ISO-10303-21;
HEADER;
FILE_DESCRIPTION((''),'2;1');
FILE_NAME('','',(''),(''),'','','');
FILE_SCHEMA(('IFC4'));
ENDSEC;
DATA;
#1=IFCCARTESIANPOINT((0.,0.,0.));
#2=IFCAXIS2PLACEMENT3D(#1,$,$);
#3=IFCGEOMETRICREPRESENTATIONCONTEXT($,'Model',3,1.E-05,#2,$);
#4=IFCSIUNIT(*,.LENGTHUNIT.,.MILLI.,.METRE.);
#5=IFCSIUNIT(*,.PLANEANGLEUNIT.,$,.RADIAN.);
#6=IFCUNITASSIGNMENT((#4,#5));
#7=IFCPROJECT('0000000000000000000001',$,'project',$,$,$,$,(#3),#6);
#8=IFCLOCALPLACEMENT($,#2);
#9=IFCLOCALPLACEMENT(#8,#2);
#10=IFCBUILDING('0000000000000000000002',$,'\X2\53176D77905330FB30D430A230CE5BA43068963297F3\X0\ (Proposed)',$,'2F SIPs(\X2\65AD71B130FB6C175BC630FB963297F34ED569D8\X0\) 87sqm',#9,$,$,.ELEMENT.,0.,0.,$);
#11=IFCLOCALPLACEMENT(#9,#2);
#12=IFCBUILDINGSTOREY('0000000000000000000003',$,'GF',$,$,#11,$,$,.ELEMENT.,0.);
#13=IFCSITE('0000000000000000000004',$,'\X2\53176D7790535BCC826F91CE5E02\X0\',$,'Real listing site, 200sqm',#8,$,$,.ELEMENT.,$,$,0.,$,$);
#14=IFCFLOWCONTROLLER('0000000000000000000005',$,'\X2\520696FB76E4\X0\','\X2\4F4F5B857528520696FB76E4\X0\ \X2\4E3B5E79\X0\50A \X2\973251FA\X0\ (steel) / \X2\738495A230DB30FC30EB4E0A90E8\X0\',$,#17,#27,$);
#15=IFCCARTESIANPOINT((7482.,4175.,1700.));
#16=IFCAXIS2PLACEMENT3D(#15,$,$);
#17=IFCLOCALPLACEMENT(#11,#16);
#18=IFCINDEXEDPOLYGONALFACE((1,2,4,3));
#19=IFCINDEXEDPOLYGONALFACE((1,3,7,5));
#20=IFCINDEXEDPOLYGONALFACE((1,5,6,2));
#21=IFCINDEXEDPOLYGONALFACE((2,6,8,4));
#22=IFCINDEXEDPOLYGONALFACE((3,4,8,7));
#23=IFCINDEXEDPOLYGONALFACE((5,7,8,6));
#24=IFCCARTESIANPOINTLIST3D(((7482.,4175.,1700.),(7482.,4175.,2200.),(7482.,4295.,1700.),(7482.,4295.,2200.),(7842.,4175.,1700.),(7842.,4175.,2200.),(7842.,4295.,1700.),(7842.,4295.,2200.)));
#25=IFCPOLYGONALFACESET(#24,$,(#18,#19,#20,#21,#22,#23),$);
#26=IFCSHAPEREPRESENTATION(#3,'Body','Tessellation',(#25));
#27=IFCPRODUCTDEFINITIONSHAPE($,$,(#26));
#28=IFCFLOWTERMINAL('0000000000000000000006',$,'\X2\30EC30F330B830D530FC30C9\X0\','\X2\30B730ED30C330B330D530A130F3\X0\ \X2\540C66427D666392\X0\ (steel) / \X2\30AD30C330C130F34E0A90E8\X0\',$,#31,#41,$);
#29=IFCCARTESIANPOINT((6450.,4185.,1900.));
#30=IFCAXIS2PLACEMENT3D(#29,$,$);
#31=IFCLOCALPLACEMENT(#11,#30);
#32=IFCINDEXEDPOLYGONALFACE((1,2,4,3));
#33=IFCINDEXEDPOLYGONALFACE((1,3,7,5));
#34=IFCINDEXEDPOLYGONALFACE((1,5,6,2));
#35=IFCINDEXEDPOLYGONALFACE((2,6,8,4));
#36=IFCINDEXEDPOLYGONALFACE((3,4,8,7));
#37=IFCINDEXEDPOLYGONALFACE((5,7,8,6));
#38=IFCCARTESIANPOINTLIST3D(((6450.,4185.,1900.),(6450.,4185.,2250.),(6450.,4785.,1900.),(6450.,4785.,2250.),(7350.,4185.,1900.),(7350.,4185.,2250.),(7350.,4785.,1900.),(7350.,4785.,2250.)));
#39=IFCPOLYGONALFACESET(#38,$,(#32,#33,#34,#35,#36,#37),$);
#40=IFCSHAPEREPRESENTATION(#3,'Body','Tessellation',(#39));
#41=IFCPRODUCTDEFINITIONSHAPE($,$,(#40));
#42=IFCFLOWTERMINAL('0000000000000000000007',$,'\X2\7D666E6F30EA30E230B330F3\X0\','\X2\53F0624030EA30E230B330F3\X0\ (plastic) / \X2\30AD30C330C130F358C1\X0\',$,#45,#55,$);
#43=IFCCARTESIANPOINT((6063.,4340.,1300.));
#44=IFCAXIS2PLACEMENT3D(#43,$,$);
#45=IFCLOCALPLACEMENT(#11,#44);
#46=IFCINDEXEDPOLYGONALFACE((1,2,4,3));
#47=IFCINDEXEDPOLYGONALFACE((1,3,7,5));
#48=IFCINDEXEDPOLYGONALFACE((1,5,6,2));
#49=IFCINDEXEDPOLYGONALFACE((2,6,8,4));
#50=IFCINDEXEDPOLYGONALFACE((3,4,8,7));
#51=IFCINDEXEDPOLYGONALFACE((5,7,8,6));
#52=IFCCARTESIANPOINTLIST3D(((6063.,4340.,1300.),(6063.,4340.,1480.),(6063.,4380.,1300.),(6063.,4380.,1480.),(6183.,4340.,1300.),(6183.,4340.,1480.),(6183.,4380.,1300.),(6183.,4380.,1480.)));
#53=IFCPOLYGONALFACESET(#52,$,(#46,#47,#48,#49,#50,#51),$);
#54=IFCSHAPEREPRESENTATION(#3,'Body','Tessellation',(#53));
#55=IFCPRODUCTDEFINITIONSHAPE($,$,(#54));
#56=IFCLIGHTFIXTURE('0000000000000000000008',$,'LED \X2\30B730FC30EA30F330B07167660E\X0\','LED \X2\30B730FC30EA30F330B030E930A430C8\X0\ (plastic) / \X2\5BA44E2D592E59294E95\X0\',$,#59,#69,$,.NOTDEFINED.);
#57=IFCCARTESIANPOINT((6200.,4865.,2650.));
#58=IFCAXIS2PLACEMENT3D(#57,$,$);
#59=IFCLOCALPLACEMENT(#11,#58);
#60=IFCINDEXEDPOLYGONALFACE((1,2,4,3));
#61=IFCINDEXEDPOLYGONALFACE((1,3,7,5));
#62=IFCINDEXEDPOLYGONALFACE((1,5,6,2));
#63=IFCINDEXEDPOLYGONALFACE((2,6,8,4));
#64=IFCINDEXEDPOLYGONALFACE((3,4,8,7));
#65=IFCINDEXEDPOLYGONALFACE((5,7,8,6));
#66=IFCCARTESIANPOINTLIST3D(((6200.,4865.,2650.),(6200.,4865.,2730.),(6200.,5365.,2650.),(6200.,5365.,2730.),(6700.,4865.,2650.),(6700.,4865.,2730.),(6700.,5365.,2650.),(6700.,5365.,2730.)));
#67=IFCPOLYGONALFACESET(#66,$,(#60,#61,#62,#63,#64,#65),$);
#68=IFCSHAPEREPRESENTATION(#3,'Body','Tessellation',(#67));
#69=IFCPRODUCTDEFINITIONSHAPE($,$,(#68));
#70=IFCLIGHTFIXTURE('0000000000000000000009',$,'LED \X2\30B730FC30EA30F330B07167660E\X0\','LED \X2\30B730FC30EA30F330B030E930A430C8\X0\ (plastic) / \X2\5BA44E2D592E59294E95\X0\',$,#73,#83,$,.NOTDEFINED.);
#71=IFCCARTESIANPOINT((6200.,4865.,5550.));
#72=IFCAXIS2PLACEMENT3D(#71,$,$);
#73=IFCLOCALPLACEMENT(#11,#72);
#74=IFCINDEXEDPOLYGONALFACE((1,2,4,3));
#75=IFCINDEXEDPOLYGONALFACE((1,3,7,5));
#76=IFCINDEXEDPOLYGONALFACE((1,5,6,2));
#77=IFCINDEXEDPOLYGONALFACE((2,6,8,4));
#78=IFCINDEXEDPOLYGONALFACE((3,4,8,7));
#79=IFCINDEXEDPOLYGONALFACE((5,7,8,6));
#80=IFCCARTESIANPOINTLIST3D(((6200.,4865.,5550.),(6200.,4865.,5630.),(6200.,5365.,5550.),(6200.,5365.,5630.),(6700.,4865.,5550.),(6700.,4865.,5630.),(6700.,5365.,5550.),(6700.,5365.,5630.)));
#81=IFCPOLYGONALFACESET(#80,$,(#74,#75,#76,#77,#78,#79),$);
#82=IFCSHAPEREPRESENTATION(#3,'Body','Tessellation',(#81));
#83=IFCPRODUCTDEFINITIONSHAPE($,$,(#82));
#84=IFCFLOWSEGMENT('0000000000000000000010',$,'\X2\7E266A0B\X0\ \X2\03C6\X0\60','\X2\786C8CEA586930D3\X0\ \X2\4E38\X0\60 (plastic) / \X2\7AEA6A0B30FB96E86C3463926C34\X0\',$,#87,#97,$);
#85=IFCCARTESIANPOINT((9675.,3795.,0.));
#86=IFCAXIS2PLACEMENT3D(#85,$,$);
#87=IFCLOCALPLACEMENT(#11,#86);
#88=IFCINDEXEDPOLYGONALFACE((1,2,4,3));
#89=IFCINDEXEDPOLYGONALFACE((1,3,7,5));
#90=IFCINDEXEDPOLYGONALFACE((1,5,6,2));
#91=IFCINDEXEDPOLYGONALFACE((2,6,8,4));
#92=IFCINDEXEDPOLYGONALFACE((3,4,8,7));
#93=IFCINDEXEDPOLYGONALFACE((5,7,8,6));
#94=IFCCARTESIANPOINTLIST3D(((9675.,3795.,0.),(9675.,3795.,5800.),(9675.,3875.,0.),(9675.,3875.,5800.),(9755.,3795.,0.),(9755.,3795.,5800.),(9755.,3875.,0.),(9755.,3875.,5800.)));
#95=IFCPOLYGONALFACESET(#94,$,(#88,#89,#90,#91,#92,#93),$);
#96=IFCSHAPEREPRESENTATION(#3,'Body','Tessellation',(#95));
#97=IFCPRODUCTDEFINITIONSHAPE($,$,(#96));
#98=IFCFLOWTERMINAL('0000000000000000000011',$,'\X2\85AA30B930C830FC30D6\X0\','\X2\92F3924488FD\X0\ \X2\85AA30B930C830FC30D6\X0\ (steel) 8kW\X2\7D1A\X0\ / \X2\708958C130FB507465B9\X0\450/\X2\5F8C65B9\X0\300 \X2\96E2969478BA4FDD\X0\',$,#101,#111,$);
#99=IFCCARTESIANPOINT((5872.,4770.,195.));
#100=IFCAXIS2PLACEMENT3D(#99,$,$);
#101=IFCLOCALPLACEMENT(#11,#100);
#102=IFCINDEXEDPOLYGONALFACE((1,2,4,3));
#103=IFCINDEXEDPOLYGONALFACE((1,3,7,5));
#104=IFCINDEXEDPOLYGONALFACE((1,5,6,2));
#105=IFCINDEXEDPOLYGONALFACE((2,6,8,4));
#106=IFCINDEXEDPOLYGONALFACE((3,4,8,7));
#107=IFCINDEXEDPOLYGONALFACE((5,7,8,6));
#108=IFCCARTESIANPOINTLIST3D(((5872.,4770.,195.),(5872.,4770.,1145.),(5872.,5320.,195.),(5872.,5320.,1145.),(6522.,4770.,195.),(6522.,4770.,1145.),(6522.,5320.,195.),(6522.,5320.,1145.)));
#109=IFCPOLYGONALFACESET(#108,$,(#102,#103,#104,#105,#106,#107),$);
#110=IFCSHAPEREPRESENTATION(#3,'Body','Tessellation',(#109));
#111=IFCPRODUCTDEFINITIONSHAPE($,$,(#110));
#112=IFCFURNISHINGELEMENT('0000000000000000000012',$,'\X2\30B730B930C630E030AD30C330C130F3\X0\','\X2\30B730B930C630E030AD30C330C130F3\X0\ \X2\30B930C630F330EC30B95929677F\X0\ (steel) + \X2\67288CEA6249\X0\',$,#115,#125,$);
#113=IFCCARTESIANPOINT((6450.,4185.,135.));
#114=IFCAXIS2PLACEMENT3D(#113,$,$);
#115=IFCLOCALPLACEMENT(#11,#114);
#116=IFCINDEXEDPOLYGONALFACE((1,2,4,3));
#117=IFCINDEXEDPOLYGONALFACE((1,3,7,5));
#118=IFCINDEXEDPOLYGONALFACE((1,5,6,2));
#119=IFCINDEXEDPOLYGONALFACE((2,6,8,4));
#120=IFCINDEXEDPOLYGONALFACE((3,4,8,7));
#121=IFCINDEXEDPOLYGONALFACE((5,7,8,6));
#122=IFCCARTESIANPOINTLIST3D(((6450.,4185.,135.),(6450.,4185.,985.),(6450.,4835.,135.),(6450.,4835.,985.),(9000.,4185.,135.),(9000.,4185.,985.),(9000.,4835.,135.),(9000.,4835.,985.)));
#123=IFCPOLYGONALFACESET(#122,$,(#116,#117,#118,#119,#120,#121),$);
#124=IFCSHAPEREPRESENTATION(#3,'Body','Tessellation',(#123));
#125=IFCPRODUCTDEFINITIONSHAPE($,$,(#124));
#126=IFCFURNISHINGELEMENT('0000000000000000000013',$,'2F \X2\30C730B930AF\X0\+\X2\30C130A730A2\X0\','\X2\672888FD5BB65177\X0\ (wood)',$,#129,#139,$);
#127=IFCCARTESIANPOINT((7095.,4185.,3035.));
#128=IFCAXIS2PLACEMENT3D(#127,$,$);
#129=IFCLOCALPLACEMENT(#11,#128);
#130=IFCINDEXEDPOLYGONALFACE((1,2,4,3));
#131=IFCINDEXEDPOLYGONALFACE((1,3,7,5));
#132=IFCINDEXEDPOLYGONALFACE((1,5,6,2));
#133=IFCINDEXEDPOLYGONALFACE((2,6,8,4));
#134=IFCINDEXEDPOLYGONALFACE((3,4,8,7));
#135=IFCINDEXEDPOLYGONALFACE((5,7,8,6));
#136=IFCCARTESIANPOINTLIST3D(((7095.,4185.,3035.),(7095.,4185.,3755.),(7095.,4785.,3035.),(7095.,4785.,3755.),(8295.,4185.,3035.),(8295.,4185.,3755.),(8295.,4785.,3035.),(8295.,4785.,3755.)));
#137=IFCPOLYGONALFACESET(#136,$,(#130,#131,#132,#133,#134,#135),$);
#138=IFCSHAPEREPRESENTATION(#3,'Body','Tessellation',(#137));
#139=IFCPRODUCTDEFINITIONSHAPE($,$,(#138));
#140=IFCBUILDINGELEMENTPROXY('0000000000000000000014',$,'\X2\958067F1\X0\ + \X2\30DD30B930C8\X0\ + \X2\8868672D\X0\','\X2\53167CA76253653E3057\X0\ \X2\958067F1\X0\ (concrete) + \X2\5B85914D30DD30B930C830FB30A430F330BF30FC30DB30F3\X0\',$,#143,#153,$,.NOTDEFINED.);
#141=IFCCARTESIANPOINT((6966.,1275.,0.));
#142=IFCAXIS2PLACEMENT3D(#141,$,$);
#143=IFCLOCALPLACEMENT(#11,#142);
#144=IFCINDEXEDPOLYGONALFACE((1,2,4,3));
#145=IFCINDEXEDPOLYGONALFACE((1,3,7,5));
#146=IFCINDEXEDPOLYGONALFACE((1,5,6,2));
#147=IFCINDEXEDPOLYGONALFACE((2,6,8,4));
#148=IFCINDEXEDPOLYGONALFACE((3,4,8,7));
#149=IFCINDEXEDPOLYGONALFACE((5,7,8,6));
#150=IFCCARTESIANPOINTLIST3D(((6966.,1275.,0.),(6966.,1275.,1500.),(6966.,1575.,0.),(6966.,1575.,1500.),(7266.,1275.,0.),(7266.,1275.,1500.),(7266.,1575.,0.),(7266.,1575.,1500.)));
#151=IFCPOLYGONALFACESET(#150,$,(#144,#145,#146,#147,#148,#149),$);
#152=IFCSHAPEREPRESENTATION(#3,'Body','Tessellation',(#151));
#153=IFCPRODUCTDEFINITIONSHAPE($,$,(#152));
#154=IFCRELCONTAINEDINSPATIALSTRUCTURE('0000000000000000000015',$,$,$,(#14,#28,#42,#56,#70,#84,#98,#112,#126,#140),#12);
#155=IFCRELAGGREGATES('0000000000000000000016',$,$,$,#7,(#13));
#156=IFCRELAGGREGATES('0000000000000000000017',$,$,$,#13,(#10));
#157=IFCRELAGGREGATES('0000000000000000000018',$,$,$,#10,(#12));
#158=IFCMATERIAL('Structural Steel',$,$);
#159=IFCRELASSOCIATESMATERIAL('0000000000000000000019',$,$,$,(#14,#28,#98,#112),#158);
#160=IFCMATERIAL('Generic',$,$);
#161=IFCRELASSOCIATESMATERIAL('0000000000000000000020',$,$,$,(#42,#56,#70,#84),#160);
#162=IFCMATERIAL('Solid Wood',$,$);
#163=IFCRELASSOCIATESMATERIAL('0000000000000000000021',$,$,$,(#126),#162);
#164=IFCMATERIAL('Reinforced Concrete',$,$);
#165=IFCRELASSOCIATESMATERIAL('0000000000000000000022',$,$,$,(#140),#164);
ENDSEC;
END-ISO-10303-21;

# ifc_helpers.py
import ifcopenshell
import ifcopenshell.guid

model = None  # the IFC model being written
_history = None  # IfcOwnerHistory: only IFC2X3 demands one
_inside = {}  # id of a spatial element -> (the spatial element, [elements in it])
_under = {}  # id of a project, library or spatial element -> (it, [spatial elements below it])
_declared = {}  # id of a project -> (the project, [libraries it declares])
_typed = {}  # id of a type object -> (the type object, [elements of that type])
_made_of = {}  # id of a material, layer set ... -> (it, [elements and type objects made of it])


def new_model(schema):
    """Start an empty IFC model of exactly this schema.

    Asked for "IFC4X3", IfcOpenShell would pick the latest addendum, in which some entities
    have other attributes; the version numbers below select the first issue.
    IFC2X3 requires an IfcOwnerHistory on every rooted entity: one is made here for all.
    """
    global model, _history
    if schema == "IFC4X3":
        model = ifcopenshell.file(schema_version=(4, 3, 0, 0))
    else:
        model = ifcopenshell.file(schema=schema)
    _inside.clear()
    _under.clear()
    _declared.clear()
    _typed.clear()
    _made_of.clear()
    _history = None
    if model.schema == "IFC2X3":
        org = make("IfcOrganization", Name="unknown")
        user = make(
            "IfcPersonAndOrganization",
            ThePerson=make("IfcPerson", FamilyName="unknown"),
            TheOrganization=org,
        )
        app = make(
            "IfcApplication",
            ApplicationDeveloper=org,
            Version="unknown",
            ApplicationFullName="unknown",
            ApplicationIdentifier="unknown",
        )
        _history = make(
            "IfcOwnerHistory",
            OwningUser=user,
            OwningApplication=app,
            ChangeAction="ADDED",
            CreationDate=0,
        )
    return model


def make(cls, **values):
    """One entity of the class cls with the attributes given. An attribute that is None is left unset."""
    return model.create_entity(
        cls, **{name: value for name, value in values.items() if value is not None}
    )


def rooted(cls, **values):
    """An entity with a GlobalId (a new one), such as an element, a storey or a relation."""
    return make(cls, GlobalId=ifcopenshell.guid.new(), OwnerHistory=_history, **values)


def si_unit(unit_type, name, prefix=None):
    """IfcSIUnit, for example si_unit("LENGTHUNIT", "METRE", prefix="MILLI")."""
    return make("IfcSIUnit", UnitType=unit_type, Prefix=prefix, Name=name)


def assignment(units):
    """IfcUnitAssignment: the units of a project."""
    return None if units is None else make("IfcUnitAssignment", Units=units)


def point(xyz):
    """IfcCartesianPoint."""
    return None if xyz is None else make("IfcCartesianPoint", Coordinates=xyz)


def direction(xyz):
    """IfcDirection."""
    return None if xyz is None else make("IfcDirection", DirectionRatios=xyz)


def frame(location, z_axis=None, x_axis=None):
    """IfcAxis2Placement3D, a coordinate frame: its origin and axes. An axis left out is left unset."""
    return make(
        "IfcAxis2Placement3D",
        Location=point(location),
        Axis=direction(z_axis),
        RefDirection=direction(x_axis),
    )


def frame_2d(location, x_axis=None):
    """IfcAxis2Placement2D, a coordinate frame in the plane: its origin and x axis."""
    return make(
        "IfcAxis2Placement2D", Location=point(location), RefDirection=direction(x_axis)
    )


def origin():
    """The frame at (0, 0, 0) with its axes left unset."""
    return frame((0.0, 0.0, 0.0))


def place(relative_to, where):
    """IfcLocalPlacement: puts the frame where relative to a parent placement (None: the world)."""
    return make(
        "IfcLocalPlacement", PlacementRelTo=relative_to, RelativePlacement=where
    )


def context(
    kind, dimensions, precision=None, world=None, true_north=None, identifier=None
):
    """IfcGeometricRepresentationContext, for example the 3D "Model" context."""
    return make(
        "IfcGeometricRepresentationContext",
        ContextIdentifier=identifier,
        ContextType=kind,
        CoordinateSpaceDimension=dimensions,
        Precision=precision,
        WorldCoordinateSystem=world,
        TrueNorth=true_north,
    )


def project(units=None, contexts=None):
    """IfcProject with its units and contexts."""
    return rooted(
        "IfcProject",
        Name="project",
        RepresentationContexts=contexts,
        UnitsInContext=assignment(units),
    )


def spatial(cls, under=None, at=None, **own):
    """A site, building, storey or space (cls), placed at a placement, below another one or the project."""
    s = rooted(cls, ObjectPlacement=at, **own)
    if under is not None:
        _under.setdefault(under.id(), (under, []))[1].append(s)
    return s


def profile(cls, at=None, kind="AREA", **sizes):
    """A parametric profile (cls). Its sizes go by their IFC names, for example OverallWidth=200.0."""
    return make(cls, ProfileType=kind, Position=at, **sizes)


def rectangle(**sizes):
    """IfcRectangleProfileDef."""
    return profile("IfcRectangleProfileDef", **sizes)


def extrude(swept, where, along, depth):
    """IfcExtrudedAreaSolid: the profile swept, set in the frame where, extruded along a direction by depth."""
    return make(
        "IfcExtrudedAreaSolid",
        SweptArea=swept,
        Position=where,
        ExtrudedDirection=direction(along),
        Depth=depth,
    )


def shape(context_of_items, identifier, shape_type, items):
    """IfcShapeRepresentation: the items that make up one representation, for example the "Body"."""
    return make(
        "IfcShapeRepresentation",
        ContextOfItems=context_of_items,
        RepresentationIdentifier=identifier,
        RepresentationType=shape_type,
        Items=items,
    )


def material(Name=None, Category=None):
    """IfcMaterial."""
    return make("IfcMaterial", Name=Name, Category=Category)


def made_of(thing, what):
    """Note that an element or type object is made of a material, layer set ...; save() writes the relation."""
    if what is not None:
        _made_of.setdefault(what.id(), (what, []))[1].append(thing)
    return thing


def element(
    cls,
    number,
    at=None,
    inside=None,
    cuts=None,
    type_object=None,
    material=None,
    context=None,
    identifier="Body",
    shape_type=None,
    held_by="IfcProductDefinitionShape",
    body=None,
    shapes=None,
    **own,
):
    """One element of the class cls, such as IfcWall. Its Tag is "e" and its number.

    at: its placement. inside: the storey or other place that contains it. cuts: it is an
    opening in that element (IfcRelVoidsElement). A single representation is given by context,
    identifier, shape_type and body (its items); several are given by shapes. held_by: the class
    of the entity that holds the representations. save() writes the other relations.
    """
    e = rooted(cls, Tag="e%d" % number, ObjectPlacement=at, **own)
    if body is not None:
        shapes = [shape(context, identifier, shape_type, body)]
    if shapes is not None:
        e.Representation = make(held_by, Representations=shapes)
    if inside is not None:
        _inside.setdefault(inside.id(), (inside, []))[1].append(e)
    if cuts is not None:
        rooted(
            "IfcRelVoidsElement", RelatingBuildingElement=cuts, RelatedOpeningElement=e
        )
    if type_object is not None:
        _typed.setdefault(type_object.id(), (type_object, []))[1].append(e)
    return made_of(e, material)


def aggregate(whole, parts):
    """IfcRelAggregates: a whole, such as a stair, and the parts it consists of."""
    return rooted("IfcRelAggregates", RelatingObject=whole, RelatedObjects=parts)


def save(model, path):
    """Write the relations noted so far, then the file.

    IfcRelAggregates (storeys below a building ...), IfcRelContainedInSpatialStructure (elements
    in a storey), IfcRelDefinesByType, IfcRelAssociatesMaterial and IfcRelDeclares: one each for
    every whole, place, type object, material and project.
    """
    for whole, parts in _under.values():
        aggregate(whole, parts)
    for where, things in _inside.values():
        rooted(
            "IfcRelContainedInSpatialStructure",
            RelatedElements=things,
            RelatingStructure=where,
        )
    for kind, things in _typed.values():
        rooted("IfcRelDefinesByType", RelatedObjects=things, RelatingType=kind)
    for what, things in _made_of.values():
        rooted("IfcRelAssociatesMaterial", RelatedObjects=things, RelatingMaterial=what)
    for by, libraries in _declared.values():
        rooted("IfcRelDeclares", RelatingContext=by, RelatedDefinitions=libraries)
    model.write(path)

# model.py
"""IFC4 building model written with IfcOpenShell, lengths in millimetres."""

from ifc_helpers import new_model, si_unit, frame, frame_2d, origin, place, context, project, spatial, rectangle, extrude, material, element, save


model = new_model("IFC4")

# Units and contexts
model_context = context("Model", 3, precision=1e-05, world=origin())
ifc_project = project(units=[si_unit("LENGTHUNIT", "METRE", prefix="MILLI"), si_unit("PLANEANGLEUNIT", "RADIAN")], contexts=[model_context])

# Site, building, storey
site_placement = place(None, origin())
site = spatial("IfcSite", under=ifc_project, at=site_placement, Name="北海道富良野市", ObjectType="Real listing site, 200sqm", CompositionType="ELEMENT", RefElevation=0.0)
building_placement = place(site_placement, origin())
building = spatial("IfcBuilding", under=site, at=building_placement, Name="北海道・ピアノ室と防音 (Proposed)", ObjectType="2F SIPs(断熱・気密・防音仕様) 87sqm", CompositionType="ELEMENT", ElevationOfRefHeight=0.0, ElevationOfTerrain=0.0)
storey_placement = place(building_placement, origin())
storey = spatial("IfcBuildingStorey", under=building, at=storey_placement, Name="GF", CompositionType="ELEMENT", Elevation=0.0)

# Shared definitions
ifc_material_1 = material(Name="Solid Wood")

# Shared definitions
ifc_material_2 = material(Name="Structural Steel")

# Shared definitions
ifc_material_3 = material(Name="Reinforced Concrete")

# Flow controller
flow_controller_placement = place(storey_placement, frame((7482.0, 4175.0, 1700.0)))
element("IfcFlowController", 1, at=flow_controller_placement, inside=storey, material=ifc_material_2, Name="分電盤", Description="住宅用分電盤 主幹50A 露出 (steel) / 玄関ホール上部", context=model_context, shape_type="SweptSolid", body=[
    extrude(rectangle(XDim=360.0, YDim=120.0, at=frame_2d((180.0, 60.0))), frame((7482.0, 4175.0, 1700.0)), (0.0, 0.0, 1.0), 500.0),
])

# Flow terminals
flow_terminal_1_placement = place(storey_placement, frame((6450.0, 4185.0, 1900.0)))
element("IfcFlowTerminal", 2, at=flow_terminal_1_placement, inside=storey, material=ifc_material_2, Name="レンジフード", Description="シロッコファン 同時給排 (steel) / キッチン上部", context=model_context, shape_type="SweptSolid", body=[
    extrude(rectangle(XDim=900.0, YDim=600.0, at=frame_2d((450.0, 300.0))), frame((6450.0, 4185.0, 1900.0)), (0.0, 0.0, 1.0), 350.0),
])
ifc_material_4 = material(Name="Generic")
flow_terminal_2_placement = place(storey_placement, frame((6063.0, 4340.0, 1300.0)))
element("IfcFlowTerminal", 3, at=flow_terminal_2_placement, inside=storey, material=ifc_material_4, Name="給湯リモコン", Description="台所リモコン (plastic) / キッチン壁", context=model_context, shape_type="SweptSolid", body=[
    extrude(rectangle(XDim=120.0, YDim=40.0, at=frame_2d((60.0, 20.0))), frame((6063.0, 4340.0, 1300.0)), (0.0, 0.0, 1.0), 180.0),
])

# Light fixtures
light_fixture_1_placement = place(storey_placement, frame((6200.0, 4865.0, 2650.0)))
element("IfcLightFixture", 4, at=light_fixture_1_placement, inside=storey, material=ifc_material_4, Name="LED シーリング照明", Description="LED シーリングライト (plastic) / 室中央天井", PredefinedType="NOTDEFINED", context=model_context, shape_type="SweptSolid", body=[
    extrude(rectangle(XDim=500.0, YDim=500.0, at=frame_2d((250.0, 250.0))), frame((6200.0, 4865.0, 2650.0)), (0.0, 0.0, 1.0), 80.0),
])
light_fixture_2_placement = place(storey_placement, frame((6200.0, 4865.0, 5550.0)))
element("IfcLightFixture", 5, at=light_fixture_2_placement, inside=storey, material=ifc_material_4, Name="LED シーリング照明", Description="LED シーリングライト (plastic) / 室中央天井", PredefinedType="NOTDEFINED", context=model_context, shape_type="SweptSolid", body=[
    extrude(rectangle(XDim=500.0, YDim=500.0, at=frame_2d((250.0, 250.0))), frame((6200.0, 4865.0, 5550.0)), (0.0, 0.0, 1.0), 80.0),
])

# Flow segment
flow_segment_placement = place(storey_placement, frame((9675.0, 3795.0, 0.0)))
element("IfcFlowSegment", 6, at=flow_segment_placement, inside=storey, material=ifc_material_4, Name="縦樋 φ60", Description="硬質塩ビ 丸60 (plastic) / 竪樋・雨水排水", context=model_context, shape_type="SweptSolid", body=[
    extrude(rectangle(XDim=80.0, YDim=80.0, at=frame_2d((40.0, 40.0))), frame((9675.0, 3795.0, 0.0)), (0.0, 0.0, 1.0), 5800.0),
])

# Flow terminal
flow_terminal_3_placement = place(storey_placement, frame((5872.0, 4770.0, 195.0)))
element("IfcFlowTerminal", 7, at=flow_terminal_3_placement, inside=storey, material=ifc_material_2, Name="薪ストーブ", Description="鋳鉄製 薪ストーブ (steel) 8kW級 / 炉壁・側方450/後方300 離隔確保", context=model_context, shape_type="SweptSolid", body=[
    extrude(rectangle(XDim=650.0, YDim=550.0, at=frame_2d((325.0, 275.0))), frame((5872.0, 4770.0, 195.0)), (0.0, 0.0, 1.0), 950.0),
])

# Furnishing elements
furnishing_1_placement = place(storey_placement, frame((6450.0, 4185.0, 135.0)))
element("IfcFurnishingElement", 8, at=furnishing_1_placement, inside=storey, material=ifc_material_2, Name="システムキッチン", Description="システムキッチン ステンレス天板 (steel) + 木質扉", context=model_context, shape_type="SweptSolid", body=[
    extrude(rectangle(XDim=2550.0, YDim=650.0, at=frame_2d((1275.0, 325.0))), frame((6450.0, 4185.0, 135.0)), (0.0, 0.0, 1.0), 850.0),
])
furnishing_2_placement = place(storey_placement, frame((7095.0, 4185.0, 3035.0)))
element("IfcFurnishingElement", 9, at=furnishing_2_placement, inside=storey, material=ifc_material_1, Name="2F デスク+チェア", Description="木製家具 (wood)", context=model_context, shape_type="SweptSolid", body=[
    extrude(rectangle(XDim=1200.0, YDim=600.0, at=frame_2d((600.0, 300.0))), frame((7095.0, 4185.0, 3035.0)), (0.0, 0.0, 1.0), 720.0),
])

# Building element proxy
proxy_placement = place(storey_placement, frame((6966.0, 1275.0, 0.0)))
element("IfcBuildingElementProxy", 10, at=proxy_placement, inside=storey, material=ifc_material_3, Name="門柱 + ポスト + 表札", Description="化粧打放し 門柱 (concrete) + 宅配ポスト・インターホン", PredefinedType="NOTDEFINED", context=model_context, shape_type="SweptSolid", body=[
    extrude(rectangle(XDim=300.0, YDim=300.0, at=frame_2d((150.0, 150.0))), frame((6966.0, 1275.0, 0.0)), (0.0, 0.0, 1.0), 1500.0),
])

save(model, "model.ifc")
